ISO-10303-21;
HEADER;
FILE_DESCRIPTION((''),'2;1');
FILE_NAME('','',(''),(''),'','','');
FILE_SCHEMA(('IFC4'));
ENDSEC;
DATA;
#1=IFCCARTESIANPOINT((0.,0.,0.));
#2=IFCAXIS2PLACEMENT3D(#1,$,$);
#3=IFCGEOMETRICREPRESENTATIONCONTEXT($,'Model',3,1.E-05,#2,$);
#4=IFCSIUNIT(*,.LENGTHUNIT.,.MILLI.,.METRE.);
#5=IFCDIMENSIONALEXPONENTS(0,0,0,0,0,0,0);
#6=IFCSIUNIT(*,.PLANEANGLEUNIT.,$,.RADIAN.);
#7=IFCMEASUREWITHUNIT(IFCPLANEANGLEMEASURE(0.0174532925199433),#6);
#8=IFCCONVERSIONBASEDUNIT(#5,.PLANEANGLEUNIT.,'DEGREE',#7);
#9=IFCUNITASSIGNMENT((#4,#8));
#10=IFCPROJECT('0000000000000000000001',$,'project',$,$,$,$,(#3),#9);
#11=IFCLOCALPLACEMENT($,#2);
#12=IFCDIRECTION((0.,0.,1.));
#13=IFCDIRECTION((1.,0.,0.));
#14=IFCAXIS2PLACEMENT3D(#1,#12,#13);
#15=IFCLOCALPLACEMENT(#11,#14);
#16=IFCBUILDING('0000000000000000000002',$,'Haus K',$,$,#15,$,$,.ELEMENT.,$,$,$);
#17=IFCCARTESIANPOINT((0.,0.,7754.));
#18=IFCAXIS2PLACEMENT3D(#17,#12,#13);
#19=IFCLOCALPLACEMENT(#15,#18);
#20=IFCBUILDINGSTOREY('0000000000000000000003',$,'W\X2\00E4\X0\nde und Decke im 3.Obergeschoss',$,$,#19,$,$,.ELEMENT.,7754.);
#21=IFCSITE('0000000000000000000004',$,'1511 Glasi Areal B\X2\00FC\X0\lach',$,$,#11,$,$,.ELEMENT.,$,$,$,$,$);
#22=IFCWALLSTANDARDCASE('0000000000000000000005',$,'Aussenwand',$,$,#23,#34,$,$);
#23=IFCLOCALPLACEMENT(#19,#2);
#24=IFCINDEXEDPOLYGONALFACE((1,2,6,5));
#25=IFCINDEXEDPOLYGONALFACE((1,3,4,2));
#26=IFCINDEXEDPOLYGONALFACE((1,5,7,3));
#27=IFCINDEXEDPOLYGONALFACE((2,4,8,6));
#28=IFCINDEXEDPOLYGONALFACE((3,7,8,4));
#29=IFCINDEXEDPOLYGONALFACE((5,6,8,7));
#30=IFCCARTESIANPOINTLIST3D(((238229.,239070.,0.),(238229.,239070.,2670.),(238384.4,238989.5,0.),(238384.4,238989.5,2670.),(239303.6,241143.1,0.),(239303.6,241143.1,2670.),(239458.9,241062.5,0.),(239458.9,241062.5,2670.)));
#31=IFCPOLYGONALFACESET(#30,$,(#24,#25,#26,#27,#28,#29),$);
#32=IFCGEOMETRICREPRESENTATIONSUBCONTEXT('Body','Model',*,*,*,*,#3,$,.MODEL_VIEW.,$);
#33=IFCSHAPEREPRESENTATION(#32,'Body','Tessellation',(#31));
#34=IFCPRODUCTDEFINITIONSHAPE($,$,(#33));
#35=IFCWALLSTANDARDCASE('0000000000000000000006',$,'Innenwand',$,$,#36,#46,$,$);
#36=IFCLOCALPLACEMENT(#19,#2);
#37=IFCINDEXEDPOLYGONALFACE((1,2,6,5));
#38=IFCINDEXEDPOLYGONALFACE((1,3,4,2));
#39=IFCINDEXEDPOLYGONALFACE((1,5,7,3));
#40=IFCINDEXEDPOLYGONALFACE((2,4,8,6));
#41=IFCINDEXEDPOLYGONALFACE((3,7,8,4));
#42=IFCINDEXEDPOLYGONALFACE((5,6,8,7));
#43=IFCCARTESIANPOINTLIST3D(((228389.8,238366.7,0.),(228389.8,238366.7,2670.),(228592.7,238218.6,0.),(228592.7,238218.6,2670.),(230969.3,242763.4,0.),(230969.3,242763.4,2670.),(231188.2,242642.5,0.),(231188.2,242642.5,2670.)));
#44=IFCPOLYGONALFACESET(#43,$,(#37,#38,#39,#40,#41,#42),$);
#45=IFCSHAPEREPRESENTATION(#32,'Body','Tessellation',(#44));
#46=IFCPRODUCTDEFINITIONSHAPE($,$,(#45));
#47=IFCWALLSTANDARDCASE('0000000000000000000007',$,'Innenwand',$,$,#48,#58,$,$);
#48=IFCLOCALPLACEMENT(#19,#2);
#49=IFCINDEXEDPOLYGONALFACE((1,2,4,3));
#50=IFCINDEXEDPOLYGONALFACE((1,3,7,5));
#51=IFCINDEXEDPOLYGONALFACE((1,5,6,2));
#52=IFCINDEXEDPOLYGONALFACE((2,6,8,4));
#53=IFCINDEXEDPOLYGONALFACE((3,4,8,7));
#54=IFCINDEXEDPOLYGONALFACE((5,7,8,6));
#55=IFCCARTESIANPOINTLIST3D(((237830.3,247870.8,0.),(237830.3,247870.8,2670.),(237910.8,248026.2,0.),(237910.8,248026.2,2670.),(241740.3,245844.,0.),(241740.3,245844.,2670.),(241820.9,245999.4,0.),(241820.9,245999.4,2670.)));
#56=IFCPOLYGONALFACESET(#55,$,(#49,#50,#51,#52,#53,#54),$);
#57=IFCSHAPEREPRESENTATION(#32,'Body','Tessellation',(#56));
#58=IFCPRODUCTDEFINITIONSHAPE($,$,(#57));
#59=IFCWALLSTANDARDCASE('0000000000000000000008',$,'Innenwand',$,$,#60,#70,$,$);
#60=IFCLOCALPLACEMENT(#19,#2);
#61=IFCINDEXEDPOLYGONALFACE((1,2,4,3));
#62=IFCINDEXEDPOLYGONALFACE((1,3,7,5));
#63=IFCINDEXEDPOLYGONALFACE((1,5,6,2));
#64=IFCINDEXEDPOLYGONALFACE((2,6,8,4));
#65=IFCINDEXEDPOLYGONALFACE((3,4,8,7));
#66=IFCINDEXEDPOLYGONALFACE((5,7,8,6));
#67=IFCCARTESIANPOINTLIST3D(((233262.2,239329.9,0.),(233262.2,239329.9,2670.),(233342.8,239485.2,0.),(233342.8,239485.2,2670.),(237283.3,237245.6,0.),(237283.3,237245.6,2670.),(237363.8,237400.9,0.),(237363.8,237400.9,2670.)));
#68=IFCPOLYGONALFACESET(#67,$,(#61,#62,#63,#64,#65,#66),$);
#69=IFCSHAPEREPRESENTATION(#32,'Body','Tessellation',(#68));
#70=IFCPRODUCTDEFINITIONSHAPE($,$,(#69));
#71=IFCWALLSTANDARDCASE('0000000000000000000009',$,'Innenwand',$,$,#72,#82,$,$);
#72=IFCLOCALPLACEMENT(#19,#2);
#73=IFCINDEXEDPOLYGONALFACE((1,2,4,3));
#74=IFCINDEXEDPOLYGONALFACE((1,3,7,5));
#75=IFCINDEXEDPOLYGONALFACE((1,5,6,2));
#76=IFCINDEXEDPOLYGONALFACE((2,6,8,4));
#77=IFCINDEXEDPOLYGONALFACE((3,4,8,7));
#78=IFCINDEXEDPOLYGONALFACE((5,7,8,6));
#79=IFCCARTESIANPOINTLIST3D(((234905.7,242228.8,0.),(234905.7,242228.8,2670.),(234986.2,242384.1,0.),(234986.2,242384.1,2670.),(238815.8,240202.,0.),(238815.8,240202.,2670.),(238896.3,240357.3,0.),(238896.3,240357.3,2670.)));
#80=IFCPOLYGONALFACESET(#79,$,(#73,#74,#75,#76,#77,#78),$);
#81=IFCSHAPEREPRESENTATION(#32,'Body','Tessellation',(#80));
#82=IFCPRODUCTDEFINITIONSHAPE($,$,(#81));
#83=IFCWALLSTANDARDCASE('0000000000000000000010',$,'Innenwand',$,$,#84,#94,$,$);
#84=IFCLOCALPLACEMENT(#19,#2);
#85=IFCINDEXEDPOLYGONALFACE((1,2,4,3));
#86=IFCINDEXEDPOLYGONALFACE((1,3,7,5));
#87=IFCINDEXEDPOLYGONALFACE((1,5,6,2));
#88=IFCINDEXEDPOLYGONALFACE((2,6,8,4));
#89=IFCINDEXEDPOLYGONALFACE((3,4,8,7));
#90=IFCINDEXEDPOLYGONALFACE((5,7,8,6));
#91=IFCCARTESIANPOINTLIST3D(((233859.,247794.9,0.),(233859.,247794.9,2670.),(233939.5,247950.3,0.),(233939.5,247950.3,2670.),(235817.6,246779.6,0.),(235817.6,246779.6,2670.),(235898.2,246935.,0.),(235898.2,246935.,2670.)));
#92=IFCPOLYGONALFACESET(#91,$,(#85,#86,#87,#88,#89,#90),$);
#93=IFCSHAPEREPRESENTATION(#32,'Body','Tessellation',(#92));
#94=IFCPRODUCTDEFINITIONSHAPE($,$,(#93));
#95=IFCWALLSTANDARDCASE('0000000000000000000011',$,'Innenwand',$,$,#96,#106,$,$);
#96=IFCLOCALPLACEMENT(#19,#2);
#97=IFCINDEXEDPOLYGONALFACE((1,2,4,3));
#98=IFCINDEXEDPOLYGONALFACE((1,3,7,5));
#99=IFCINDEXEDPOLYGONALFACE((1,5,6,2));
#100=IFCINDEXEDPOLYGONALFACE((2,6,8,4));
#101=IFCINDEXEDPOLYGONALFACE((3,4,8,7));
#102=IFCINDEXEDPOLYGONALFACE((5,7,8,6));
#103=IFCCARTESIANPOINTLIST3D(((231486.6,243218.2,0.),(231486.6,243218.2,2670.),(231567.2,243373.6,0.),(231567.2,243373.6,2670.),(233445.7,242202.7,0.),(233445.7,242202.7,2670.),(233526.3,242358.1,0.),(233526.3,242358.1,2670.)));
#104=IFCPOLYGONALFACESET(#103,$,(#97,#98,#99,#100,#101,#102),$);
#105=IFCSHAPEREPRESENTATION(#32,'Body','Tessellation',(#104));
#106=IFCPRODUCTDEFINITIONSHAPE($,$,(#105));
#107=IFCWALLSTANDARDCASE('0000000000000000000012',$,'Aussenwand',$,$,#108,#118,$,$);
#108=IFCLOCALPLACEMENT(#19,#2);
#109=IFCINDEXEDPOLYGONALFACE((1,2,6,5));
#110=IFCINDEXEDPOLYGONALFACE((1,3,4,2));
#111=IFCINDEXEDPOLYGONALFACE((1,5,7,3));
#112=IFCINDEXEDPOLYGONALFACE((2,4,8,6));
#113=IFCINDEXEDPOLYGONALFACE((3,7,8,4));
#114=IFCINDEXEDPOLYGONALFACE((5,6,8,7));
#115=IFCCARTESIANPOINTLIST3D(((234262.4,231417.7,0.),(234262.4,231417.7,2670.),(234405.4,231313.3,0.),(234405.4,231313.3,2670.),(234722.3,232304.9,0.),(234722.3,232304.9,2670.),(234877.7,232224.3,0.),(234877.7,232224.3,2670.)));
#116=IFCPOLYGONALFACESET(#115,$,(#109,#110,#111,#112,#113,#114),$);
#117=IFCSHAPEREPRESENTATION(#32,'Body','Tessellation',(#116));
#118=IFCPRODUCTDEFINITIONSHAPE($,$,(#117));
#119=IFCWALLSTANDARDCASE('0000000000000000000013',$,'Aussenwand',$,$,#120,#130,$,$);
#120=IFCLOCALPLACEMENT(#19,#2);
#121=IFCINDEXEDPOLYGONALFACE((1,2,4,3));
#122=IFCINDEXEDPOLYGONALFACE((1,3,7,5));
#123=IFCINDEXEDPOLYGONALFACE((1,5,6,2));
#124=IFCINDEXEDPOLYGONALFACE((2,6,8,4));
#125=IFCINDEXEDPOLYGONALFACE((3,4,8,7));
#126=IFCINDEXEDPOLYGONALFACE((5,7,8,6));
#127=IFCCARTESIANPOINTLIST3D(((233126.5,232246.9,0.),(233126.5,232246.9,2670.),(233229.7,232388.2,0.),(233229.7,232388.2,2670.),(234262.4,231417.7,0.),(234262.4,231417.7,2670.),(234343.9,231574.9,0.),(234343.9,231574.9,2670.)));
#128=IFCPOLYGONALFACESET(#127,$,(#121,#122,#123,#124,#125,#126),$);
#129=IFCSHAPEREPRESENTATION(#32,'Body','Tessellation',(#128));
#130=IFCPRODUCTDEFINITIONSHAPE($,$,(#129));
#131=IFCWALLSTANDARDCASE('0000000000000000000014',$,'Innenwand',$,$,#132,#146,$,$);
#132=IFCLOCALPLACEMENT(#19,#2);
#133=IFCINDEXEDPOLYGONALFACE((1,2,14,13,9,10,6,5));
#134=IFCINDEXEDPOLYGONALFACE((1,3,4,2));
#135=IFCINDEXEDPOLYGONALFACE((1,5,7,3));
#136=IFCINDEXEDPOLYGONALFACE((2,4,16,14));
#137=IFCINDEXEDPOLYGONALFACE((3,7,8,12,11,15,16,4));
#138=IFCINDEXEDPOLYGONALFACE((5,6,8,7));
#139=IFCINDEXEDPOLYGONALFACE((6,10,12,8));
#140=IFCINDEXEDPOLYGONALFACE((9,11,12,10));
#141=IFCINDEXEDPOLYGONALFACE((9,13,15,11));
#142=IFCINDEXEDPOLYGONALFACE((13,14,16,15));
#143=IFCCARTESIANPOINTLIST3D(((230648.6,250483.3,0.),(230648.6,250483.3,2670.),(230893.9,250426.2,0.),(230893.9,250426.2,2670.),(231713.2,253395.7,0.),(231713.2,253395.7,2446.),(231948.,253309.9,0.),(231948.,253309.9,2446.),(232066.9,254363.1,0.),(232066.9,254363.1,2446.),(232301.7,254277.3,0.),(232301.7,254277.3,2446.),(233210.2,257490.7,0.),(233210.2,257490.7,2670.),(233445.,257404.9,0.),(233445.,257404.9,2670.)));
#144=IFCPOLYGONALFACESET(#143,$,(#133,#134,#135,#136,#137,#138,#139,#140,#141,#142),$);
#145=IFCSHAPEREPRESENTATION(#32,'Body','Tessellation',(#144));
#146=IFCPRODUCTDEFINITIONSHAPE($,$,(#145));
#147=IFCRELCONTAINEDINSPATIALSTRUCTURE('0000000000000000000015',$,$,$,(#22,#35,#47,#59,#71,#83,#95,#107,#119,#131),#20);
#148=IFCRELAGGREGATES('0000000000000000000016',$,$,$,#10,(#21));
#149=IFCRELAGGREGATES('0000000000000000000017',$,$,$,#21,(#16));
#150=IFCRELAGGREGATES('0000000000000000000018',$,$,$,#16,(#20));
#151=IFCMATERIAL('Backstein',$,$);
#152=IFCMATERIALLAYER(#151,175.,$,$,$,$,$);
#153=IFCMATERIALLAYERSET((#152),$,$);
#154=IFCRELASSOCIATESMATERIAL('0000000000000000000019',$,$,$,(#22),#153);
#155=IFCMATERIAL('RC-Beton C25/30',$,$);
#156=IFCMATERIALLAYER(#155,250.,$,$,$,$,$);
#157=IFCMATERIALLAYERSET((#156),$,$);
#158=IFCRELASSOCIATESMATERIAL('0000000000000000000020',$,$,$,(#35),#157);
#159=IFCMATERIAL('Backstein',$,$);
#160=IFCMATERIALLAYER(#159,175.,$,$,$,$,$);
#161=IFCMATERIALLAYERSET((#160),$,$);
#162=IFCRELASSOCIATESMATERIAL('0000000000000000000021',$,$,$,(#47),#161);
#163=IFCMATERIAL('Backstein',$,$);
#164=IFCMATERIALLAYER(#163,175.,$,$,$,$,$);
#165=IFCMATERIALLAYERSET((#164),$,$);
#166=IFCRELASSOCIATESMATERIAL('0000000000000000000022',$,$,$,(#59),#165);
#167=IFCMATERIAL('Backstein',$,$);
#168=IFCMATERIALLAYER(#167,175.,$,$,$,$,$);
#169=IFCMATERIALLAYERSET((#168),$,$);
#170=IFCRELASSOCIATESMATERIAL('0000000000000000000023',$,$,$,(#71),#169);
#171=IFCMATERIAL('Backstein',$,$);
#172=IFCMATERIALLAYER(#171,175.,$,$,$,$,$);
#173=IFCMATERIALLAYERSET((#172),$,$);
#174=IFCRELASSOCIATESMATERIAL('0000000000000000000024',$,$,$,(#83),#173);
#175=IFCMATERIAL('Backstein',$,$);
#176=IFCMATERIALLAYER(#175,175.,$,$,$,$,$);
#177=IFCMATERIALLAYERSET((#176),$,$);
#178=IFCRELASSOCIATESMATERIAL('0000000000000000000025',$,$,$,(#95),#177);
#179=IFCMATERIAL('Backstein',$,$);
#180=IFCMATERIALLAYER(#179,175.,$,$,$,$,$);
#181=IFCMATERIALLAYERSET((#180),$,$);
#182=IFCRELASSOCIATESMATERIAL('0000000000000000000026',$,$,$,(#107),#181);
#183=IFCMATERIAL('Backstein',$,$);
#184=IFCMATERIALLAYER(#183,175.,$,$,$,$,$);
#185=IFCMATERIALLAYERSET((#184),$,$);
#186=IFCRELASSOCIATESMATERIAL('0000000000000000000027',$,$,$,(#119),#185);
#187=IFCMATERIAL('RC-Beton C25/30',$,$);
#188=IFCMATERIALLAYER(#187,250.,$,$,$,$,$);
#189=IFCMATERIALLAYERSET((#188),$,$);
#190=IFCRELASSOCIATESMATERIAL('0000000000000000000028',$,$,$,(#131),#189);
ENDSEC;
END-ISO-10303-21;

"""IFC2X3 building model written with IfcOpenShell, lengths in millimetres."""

from ifc_helpers import new_model, entity, si_unit, converted_unit, frame, frame_2d, origin, origin_with_axes, place, context, subcontext, project, spatial, polyline, rectangle, outline, extrude, material, layer, layer_set, layer_usage, element, save


model = new_model("IFC2X3")

# Units and contexts
model_context = context("Model", 3, precision=1e-05, world=origin())
body_context = subcontext(model_context, "Body", "Model", "MODEL_VIEW")
ifc_project = project(units=[si_unit("LENGTHUNIT", "METRE", prefix="MILLI"), converted_unit("PLANEANGLEUNIT", "DEGREE", entity("IfcPlaneAngleMeasure", 0.0174532925199433), si_unit("PLANEANGLEUNIT", "RADIAN"), dimensions=[0, 0, 0, 0, 0, 0, 0])], contexts=[model_context])

# Site, building, storey
site_placement = place(None, origin())
site = spatial("IfcSite", under=ifc_project, at=site_placement, Name="1511 Glasi Areal Bülach", CompositionType="ELEMENT")
building_placement = place(site_placement, origin_with_axes())
building = spatial("IfcBuilding", under=site, at=building_placement, Name="Haus K", CompositionType="ELEMENT")
storey_placement = place(building_placement, frame((0.0, 0.0, 7754.0), z_axis=(0.0, 0.0, 1.0), x_axis=(1.0, 0.0, 0.0)))
storey = spatial("IfcBuildingStorey", under=building, at=storey_placement, Name="Wände und Decke im 3.Obergeschoss", CompositionType="ELEMENT", Elevation=7754.0)

# Walls
ifc_material_1 = material(Name="Backstein")
ifc_layer_1 = layer(ifc_material_1, 175.0)
ifc_layer_set_1 = layer_set([ifc_layer_1])
ifc_layer_usage_1 = layer_usage(ifc_layer_set_1, "AXIS2", "POSITIVE", 0.0)
wall_1_placement = place(storey_placement, frame((238384.4, 238989.5, 0.0), z_axis=(0.0, 0.0, 1.0), x_axis=(0.4602, 0.887815, 0.0)))
element("IfcWallStandardCase", 1, at=wall_1_placement, inside=storey, material=ifc_layer_usage_1, Name="Aussenwand", context=body_context, shape_type="SweptSolid", body=[
    extrude(rectangle(XDim=2335.0, YDim=175.0, at=frame_2d((1167.5, 87.5), x_axis=(1.0, 0.0))), origin_with_axes(), (0.0, 0.0, 1.0), 2670.0),
])
ifc_material_2 = material(Name="RC-Beton C25/30")
ifc_layer_2 = layer(ifc_material_2, 250.0)
ifc_layer_set_2 = layer_set([ifc_layer_2])
ifc_layer_usage_2 = layer_usage(ifc_layer_set_2, "AXIS2", "POSITIVE", 0.0)
wall_2_placement = place(storey_placement, frame((230969.3, 242763.4, 0.0), z_axis=(0.0, 0.0, 1.0), x_axis=(-0.506034, -0.862514, 0.0)))
element("IfcWallStandardCase", 2, at=wall_2_placement, inside=storey, material=ifc_layer_usage_2, Name="Innenwand", context=body_context, shape_type="SweptSolid", body=[
    extrude(outline(polyline([(0.0, 0.0), (5097.5, 0.0), (5122.5, 250.0), (-6.5, 250.0), (0.0, 0.0)])), origin_with_axes(), (0.0, 0.0, 1.0), 2670.0),
])
ifc_material_3 = material(Name="Backstein")
ifc_layer_3 = layer(ifc_material_3, 175.0)
ifc_layer_set_3 = layer_set([ifc_layer_3])
ifc_layer_usage_3 = layer_usage(ifc_layer_set_3, "AXIS2", "POSITIVE", 0.0)
wall_3_placement = place(storey_placement, frame((241820.9, 245999.4, 0.0), z_axis=(0.0, 0.0, 1.0), x_axis=(-0.887815, 0.4602, 0.0)))
element("IfcWallStandardCase", 3, at=wall_3_placement, inside=storey, material=ifc_layer_usage_3, Name="Innenwand", context=body_context, shape_type="SweptSolid", body=[
    extrude(rectangle(XDim=4404.2, YDim=175.0, at=frame_2d((2202.1, 87.5), x_axis=(1.0, 0.0))), origin_with_axes(), (0.0, 0.0, 1.0), 2670.0),
])
ifc_material_4 = material(Name="Backstein")
ifc_layer_4 = layer(ifc_material_4, 175.0)
ifc_layer_set_4 = layer_set([ifc_layer_4])
ifc_layer_usage_4 = layer_usage(ifc_layer_set_4, "AXIS2", "POSITIVE", 0.0)
wall_4_placement = place(storey_placement, frame((233262.2, 239329.9, 0.0), z_axis=(0.0, 0.0, 1.0), x_axis=(0.887815, -0.4602, 0.0)))
element("IfcWallStandardCase", 4, at=wall_4_placement, inside=storey, material=ifc_layer_usage_4, Name="Innenwand", context=body_context, shape_type="SweptSolid", body=[
    extrude(rectangle(XDim=4529.2, YDim=175.0, at=frame_2d((2264.6, 87.5), x_axis=(1.0, 0.0))), origin_with_axes(), (0.0, 0.0, 1.0), 2670.0),
])
ifc_material_5 = material(Name="Backstein")
ifc_layer_5 = layer(ifc_material_5, 175.0)
ifc_layer_set_5 = layer_set([ifc_layer_5])
ifc_layer_usage_5 = layer_usage(ifc_layer_set_5, "AXIS2", "POSITIVE", 0.0)
wall_5_placement = place(storey_placement, frame((238896.3, 240357.3, 0.0), z_axis=(0.0, 0.0, 1.0), x_axis=(-0.887815, 0.4602, 0.0)))
element("IfcWallStandardCase", 5, at=wall_5_placement, inside=storey, material=ifc_layer_usage_5, Name="Innenwand", context=body_context, shape_type="SweptSolid", body=[
    extrude(rectangle(XDim=4404.2, YDim=175.0, at=frame_2d((2202.1, 87.5), x_axis=(1.0, 0.0))), origin_with_axes(), (0.0, 0.0, 1.0), 2670.0),
])
ifc_material_6 = material(Name="Backstein")
ifc_layer_6 = layer(ifc_material_6, 175.0)
ifc_layer_set_6 = layer_set([ifc_layer_6])
ifc_layer_usage_6 = layer_usage(ifc_layer_set_6, "AXIS2", "POSITIVE", 0.0)
wall_6_placement = place(storey_placement, frame((235898.2, 246935.0, 0.0), z_axis=(0.0, 0.0, 1.0), x_axis=(-0.887815, 0.4602, 0.0)))
element("IfcWallStandardCase", 6, at=wall_6_placement, inside=storey, material=ifc_layer_usage_6, Name="Innenwand", context=body_context, shape_type="SweptSolid", body=[
    extrude(rectangle(XDim=2206.2, YDim=175.0, at=frame_2d((1103.1, 87.5), x_axis=(1.0, 0.0))), origin_with_axes(), (0.0, 0.0, 1.0), 2670.0),
])
ifc_material_7 = material(Name="Backstein")
ifc_layer_7 = layer(ifc_material_7, 175.0)
ifc_layer_set_7 = layer_set([ifc_layer_7])
ifc_layer_usage_7 = layer_usage(ifc_layer_set_7, "AXIS2", "POSITIVE", 0.0)
wall_7_placement = place(storey_placement, frame((233526.3, 242358.1, 0.0), z_axis=(0.0, 0.0, 1.0), x_axis=(-0.887815, 0.4602, 0.0)))
element("IfcWallStandardCase", 7, at=wall_7_placement, inside=storey, material=ifc_layer_usage_7, Name="Innenwand", context=body_context, shape_type="SweptSolid", body=[
    extrude(rectangle(XDim=2206.6, YDim=175.0, at=frame_2d((1103.3, 87.5), x_axis=(1.0, 0.0))), origin_with_axes(), (0.0, 0.0, 1.0), 2670.0),
])
ifc_material_8 = material(Name="Backstein")
ifc_layer_8 = layer(ifc_material_8, 175.0)
ifc_layer_set_8 = layer_set([ifc_layer_8])
ifc_layer_usage_8 = layer_usage(ifc_layer_set_8, "AXIS2", "POSITIVE", 0.0)
wall_8_placement = place(storey_placement, frame((234405.4, 231313.3, 0.0), z_axis=(0.0, 0.0, 1.0), x_axis=(0.4602, 0.887815, 0.0)))
element("IfcWallStandardCase", 8, at=wall_8_placement, inside=storey, material=ifc_layer_usage_8, Name="Aussenwand", context=body_context, shape_type="SweptSolid", body=[
    extrude(outline(polyline([(0.0, 0.0), (1026.2, 0.0), (1026.2, 175.0), (26.9, 175.0), (0.0, 0.0)])), origin_with_axes(), (0.0, 0.0, 1.0), 2670.0),
])
ifc_material_9 = material(Name="Backstein")
ifc_layer_9 = layer(ifc_material_9, 175.0)
ifc_layer_set_9 = layer_set([ifc_layer_9])
ifc_layer_usage_9 = layer_usage(ifc_layer_set_9, "AXIS2", "POSITIVE", 0.0)
wall_9_placement = place(storey_placement, frame((233126.5, 232246.9, 0.0), z_axis=(0.0, 0.0, 1.0), x_axis=(0.807681, -0.589619, 0.0)))
element("IfcWallStandardCase", 9, at=wall_9_placement, inside=storey, material=ifc_layer_usage_9, Name="Aussenwand", context=body_context, shape_type="SweptSolid", body=[
    extrude(outline(polyline([(0.0, 0.0), (1406.3, 0.0), (1379.5, 175.0), (0.0, 175.0), (0.0, 0.0)])), origin_with_axes(), (0.0, 0.0, 1.0), 2670.0),
])

# Wall, opening
ifc_material_10 = material(Name="RC-Beton C25/30")
ifc_layer_10 = layer(ifc_material_10, 250.0)
ifc_layer_set_10 = layer_set([ifc_layer_10])
ifc_layer_usage_10 = layer_usage(ifc_layer_set_10, "AXIS2", "POSITIVE", 0.0)
wall_10_placement = place(storey_placement, frame((230893.9, 250426.2, 0.0), z_axis=(0.0, 0.0, 1.0), x_axis=(0.343332, 0.939214, 0.0)))
wall_10 = element("IfcWallStandardCase", 10, at=wall_10_placement, inside=storey, material=ifc_layer_usage_10, Name="Innenwand", context=body_context, shape_type="SweptSolid", body=[
    extrude(outline(polyline([(0.0, 0.0), (7430.3, 0.0), (7430.3, 250.0), (-30.6, 250.0), (0.0, 0.0)])), origin_with_axes(), (0.0, 0.0, 1.0), 2670.0),
])
opening_placement = place(wall_10_placement, frame((3070.3, 0.0, 0.0), z_axis=(0.0, 1.0, 0.0), x_axis=(0.0, 0.0, 1.0)))
element("IfcOpeningElement", 11, at=opening_placement, cuts=wall_10, ObjectType="Opening", context=body_context, shape_type="SweptSolid", body=[
    extrude(rectangle(XDim=2446.0, YDim=1030.0, at=frame_2d((1223.0, 515.0), x_axis=(1.0, 0.0))), origin_with_axes(), (0.0, 0.0, 1.0), 250.0),
])

save(model, "model.ifc")
